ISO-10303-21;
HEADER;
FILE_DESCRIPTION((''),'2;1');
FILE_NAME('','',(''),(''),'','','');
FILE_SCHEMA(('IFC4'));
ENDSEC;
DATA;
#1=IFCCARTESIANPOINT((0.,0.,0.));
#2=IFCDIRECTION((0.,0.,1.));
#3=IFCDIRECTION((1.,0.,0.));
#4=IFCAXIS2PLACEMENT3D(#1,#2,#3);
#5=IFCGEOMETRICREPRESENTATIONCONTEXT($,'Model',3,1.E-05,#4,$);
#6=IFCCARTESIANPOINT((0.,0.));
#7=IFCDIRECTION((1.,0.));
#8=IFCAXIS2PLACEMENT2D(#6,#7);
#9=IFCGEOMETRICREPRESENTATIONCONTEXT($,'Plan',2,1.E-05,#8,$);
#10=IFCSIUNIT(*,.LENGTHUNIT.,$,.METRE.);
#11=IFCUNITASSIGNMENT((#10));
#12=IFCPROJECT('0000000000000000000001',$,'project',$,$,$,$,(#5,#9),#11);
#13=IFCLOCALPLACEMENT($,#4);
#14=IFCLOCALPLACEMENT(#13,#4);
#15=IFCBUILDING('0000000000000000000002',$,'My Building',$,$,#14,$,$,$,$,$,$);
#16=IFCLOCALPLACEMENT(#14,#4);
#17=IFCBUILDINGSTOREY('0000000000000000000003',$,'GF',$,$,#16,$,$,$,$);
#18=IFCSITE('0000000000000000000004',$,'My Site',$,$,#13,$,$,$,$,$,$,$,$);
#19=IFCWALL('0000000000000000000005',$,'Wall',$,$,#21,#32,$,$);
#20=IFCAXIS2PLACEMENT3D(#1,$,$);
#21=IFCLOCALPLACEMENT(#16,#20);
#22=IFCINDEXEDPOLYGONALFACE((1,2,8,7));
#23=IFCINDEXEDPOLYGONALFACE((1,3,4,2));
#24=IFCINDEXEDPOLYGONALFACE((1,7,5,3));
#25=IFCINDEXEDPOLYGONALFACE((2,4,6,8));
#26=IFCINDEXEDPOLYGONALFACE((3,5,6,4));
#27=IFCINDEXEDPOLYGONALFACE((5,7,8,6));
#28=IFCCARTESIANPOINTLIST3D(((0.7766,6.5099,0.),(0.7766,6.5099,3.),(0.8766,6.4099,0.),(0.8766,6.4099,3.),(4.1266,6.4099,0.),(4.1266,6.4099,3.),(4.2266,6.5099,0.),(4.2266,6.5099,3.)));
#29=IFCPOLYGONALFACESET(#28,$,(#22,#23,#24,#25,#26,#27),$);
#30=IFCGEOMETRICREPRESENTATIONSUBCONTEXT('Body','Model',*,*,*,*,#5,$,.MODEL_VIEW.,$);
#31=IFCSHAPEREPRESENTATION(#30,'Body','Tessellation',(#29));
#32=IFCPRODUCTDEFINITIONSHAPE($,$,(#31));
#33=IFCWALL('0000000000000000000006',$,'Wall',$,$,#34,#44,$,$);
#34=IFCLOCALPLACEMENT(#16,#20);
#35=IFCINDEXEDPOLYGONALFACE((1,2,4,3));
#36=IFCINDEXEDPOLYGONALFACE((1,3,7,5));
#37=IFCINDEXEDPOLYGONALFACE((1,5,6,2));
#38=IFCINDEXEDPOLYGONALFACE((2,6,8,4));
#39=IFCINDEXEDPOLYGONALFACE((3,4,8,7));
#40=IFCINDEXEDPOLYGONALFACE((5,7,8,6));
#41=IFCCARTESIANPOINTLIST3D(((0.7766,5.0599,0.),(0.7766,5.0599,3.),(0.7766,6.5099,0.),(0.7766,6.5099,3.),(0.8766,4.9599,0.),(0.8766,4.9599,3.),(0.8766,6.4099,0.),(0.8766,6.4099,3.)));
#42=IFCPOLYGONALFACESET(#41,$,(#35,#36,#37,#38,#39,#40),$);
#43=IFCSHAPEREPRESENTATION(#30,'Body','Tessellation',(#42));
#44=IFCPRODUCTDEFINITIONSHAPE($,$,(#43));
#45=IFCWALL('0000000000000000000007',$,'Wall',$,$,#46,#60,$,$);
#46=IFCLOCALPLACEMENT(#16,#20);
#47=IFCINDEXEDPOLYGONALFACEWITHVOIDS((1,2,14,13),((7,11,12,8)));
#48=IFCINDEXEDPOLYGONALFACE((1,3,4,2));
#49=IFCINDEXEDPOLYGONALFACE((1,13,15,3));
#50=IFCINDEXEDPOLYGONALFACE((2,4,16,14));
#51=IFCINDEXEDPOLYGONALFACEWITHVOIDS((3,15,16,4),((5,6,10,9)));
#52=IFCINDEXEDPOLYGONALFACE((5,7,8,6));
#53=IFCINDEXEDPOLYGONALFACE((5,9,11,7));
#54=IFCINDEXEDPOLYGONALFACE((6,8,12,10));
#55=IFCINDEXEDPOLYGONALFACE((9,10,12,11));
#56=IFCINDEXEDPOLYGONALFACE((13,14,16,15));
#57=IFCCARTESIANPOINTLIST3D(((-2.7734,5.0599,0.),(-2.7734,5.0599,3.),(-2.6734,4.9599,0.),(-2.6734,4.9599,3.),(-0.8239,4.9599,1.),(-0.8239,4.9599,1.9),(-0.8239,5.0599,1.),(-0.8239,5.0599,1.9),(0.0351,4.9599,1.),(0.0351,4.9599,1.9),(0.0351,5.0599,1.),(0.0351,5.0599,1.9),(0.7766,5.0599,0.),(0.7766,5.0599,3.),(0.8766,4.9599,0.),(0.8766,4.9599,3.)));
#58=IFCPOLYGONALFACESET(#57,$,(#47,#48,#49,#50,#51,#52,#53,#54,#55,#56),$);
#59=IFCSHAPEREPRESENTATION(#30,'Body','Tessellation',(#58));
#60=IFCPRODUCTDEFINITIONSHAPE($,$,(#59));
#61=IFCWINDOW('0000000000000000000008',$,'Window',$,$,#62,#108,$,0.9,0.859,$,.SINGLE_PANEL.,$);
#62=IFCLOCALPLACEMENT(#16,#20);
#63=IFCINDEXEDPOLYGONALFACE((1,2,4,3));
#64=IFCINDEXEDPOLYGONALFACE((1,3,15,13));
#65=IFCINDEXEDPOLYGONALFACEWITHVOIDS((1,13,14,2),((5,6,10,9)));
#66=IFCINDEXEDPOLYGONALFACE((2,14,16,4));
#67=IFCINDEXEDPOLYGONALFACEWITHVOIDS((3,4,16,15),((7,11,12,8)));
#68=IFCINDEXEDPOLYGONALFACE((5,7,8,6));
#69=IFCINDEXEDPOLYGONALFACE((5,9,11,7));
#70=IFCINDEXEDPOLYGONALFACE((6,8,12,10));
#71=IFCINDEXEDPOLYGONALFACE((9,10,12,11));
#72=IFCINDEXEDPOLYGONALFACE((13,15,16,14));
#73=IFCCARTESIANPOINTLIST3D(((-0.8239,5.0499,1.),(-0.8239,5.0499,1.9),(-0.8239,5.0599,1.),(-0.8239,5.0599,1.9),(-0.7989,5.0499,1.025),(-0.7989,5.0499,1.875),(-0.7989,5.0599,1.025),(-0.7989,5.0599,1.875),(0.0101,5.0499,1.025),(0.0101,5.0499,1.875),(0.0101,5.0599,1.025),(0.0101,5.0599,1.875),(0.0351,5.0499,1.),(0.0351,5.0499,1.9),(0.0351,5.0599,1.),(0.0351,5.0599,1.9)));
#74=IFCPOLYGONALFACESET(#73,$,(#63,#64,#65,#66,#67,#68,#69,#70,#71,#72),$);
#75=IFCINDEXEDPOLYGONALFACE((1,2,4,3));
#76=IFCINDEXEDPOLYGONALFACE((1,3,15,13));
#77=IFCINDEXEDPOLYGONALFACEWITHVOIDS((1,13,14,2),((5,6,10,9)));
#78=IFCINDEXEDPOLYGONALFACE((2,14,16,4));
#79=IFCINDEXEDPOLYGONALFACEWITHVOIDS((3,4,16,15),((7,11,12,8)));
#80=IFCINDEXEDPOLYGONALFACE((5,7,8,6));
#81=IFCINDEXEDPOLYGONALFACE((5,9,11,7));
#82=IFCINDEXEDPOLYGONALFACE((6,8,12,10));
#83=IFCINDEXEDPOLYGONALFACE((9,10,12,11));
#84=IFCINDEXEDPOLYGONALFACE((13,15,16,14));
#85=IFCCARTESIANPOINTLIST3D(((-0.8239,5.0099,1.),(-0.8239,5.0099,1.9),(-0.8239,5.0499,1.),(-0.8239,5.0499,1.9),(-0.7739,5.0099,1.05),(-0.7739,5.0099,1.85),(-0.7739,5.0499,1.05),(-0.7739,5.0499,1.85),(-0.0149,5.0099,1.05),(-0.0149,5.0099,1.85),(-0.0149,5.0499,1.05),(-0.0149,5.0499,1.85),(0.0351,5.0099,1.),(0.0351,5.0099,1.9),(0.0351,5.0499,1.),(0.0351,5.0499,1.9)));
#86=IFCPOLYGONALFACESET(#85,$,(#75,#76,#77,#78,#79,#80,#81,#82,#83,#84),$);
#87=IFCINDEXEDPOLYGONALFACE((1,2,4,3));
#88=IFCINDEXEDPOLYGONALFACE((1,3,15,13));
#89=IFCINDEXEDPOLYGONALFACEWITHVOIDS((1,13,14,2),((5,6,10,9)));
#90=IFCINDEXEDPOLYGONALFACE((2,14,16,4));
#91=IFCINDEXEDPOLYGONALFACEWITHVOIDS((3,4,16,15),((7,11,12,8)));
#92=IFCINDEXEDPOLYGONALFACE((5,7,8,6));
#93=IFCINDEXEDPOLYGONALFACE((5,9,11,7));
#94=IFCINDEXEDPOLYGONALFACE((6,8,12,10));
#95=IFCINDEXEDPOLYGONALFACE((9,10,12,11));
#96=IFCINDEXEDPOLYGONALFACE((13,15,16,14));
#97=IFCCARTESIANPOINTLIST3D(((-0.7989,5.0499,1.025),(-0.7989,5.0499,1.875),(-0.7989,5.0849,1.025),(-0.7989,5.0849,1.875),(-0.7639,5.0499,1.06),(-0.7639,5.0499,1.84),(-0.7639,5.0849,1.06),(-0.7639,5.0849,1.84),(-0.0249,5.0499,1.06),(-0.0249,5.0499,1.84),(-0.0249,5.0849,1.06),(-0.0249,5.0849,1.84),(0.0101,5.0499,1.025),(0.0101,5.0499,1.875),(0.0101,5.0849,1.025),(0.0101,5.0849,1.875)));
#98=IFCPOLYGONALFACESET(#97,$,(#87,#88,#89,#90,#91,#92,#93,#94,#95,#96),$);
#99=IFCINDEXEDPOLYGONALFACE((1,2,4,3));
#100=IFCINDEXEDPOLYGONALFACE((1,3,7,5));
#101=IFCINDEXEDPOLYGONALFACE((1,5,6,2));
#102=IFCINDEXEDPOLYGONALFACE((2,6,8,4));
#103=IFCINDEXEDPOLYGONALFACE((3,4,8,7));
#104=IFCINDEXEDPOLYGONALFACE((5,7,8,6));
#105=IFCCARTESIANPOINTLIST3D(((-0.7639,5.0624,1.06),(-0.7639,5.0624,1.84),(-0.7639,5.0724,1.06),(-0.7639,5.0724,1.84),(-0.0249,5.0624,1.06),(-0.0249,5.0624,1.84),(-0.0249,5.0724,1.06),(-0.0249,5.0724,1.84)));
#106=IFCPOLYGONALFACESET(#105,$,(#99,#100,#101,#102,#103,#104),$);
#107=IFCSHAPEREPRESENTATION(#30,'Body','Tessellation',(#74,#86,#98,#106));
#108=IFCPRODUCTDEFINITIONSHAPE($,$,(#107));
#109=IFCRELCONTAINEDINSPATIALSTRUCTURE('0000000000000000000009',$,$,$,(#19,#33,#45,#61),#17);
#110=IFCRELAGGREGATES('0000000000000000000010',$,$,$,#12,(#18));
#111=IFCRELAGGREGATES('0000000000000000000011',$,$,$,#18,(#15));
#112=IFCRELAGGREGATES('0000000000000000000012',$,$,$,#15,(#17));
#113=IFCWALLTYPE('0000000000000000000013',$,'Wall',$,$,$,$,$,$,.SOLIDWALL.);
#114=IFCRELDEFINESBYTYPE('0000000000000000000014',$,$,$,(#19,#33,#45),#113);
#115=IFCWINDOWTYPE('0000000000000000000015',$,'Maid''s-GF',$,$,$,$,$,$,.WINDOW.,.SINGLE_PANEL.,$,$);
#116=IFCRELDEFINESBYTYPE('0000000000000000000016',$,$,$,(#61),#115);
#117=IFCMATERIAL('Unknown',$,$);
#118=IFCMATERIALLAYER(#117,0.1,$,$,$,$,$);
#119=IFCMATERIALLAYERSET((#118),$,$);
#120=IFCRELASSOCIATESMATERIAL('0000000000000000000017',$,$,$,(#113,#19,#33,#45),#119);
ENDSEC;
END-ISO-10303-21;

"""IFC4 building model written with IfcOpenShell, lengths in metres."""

from ifc_helpers import new_model, entity, si_unit, frame, origin_with_axes, origin_2d_with_axis, place, context, subcontext, project, spatial, line, indexed_curve, outline, extrude, shape, source, transform, mapped, material, layer, layer_set, layer_usage, type_object, type_shapes, element, fill, save


model = new_model("IFC4")

# Units and contexts
model_context = context("Model", 3, precision=1e-05, world=origin_with_axes())
plan_context = context("Plan", 2, precision=1e-05, world=origin_2d_with_axis())
body_context_1 = subcontext(model_context, "Body", "Model", "MODEL_VIEW")
body_context_2 = subcontext(plan_context, "Body", "Plan", "PLAN_VIEW")
ifc_project = project(units=[si_unit("LENGTHUNIT", "METRE")], contexts=[model_context, plan_context])

# Site, building, storey
site_placement = place(None, origin_with_axes())
site = spatial("IfcSite", under=ifc_project, at=site_placement, Name="My Site")
building_placement = place(site_placement, origin_with_axes())
building = spatial("IfcBuilding", under=site, at=building_placement, Name="My Building")
storey_placement = place(building_placement, origin_with_axes())
storey = spatial("IfcBuildingStorey", under=building, at=storey_placement, Name="GF")

# Walls
ifc_material = material(Name="Unknown")
ifc_layer = layer(ifc_material, 0.1)
ifc_layer_set = layer_set([ifc_layer])
ifc_layer_usage_1 = layer_usage(ifc_layer_set, "AXIS2", "POSITIVE", 0.0)
wall_type = type_object("IfcWallType", Name="Wall", PredefinedType="SOLIDWALL", material=ifc_layer_set)
wall_1_placement = place(storey_placement, frame((4.2266, 6.5099, 0.0), z_axis=(0.0, 0.0, 1.0), x_axis=(-1.0, 0.0, 0.0)))
element("IfcWall", 1, at=wall_1_placement, inside=storey, type_object=wall_type, material=ifc_layer_usage_1, Name="Wall", context=body_context_1, shape_type="SweptSolid", body=[
    extrude(outline(indexed_curve([(0.0, 0.0), (0.1, 0.1), (3.35, 0.1), (3.45, 0.0)], segments=[line(1, 2, 3, 4, 1)])), origin_with_axes(), (0.0, 0.0, 1.0), 3.0),
])
ifc_layer_usage_2 = layer_usage(ifc_layer_set, "AXIS2", "POSITIVE", 0.0)
wall_2_placement = place(storey_placement, frame((0.7766, 6.5099, 0.0), z_axis=(0.0, 0.0, 1.0), x_axis=(0.0, -1.0, 0.0)))
element("IfcWall", 2, at=wall_2_placement, inside=storey, type_object=wall_type, material=ifc_layer_usage_2, Name="Wall", context=body_context_1, shape_type="SweptSolid", body=[
    extrude(outline(indexed_curve([(0.0, 0.0), (0.1, 0.1), (1.55, 0.1), (1.45, 0.0)], segments=[line(1, 2, 3, 4, 1)])), origin_with_axes(), (0.0, 0.0, 1.0), 3.0),
])

# Wall, opening, window
ifc_layer_usage_3 = layer_usage(ifc_layer_set, "AXIS2", "POSITIVE", 0.0)
wall_3_placement = place(storey_placement, frame((0.7766, 5.0599, 0.0), z_axis=(0.0, 0.0, 1.0), x_axis=(-1.0, 0.0, 0.0)))
wall_3 = element("IfcWall", 3, at=wall_3_placement, inside=storey, type_object=wall_type, material=ifc_layer_usage_3, Name="Wall", context=body_context_1, shape_type="SweptSolid", body=[
    extrude(outline(indexed_curve([(0.0, 0.0), (-0.1, 0.1), (3.45, 0.1), (3.55, 0.0)], segments=[line(1, 2, 3, 4, 1)])), origin_with_axes(), (0.0, 0.0, 1.0), 3.0),
])
shared_shape_1 = source(origin_with_axes(), body_context_1, "Body", "SweptSolid", [
    extrude(outline(indexed_curve([(0.0, 0.0), (0.859, 0.0), (0.859, 0.9), (0.0, 0.9)], segments=[line(1, 2, 3, 4, 1)])), frame((0.0, -0.6, 0.0), z_axis=(0.0, -1.0, 0.0), x_axis=(1.0, 0.0, 0.0)), (0.0, 0.0, -1.0), 1.2),
])
opening_1_placement = place(wall_3_placement, frame((1.6005, 0.1, 1.0), z_axis=(0.0, 0.0, 1.0), x_axis=(-1.0, 0.000001, 0.0)))
opening_1 = element("IfcOpeningElement", 4, at=opening_1_placement, cuts=wall_3, PredefinedType="OPENING", context=body_context_1, shape_type="MappedRepresentation", body=[
    mapped(shared_shape_1, transform((0.0, 0.0, 0.0), x_axis=(1.0, 0.0, 0.0), y_axis=(0.0, 1.0, 0.0), z_axis=(0.0, 0.0, 1.0), scale=1.0)),
])
window_type_1 = type_object("IfcWindowType", Name="Maid's-GF", PartitioningType="SINGLE_PANEL", PredefinedType="WINDOW")
shared_shape_2 = source(origin_with_axes(), body_context_1, "Body", "SweptSolid", [
    extrude(outline(indexed_curve([(0.0, 0.0), (0.859, 0.0), (0.859, 0.9), (0.0, 0.9)], segments=[line(1, 2, 3, 4, 1)]), holes=[indexed_curve([(0.025, 0.025), (0.834, 0.025), (0.834, 0.875), (0.025, 0.875)], segments=[line(1, 2, 3, 4, 1)])]), frame((0.0, 0.09, 0.0), z_axis=(0.0, -1.0, 0.0), x_axis=(1.0, 0.0, 0.0)), (0.0, 0.0, -1.0), 0.01),
    extrude(outline(indexed_curve([(0.0, 0.0), (0.859, 0.0), (0.859, 0.9), (0.0, 0.9)], segments=[line(1, 2, 3, 4, 1)]), holes=[indexed_curve([(0.05, 0.05), (0.809, 0.05), (0.809, 0.85), (0.05, 0.85)], segments=[line(1, 2, 3, 4, 1)])]), frame((0.0, 0.05, 0.0), z_axis=(0.0, -1.0, 0.0), x_axis=(1.0, 0.0, 0.0)), (0.0, 0.0, -1.0), 0.04),
    extrude(outline(indexed_curve([(0.0, 0.0), (0.809, 0.0), (0.809, 0.85), (0.0, 0.85)], segments=[line(1, 2, 3, 4, 1)]), holes=[indexed_curve([(0.035, 0.035), (0.774, 0.035), (0.774, 0.815), (0.035, 0.815)], segments=[line(1, 2, 3, 4, 1)])]), frame((0.025, 0.09, 0.025), z_axis=(0.0, -1.0, 0.0), x_axis=(1.0, 0.0, 0.0)), (0.0, 0.0, -1.0), 0.035),
    extrude(outline(indexed_curve([(0.035, 0.035), (0.774, 0.035), (0.774, 0.815), (0.035, 0.815)], segments=[line(1, 2, 3, 4, 1)])), frame((0.025, 0.1025, 0.025), z_axis=(0.0, -1.0, 0.0), x_axis=(1.0, 0.0, 0.0)), (0.0, 0.0, -1.0), 0.01),
])
shared_shape_3 = source(origin_with_axes(), body_context_2, "Body", "Curve2D", [
    entity("IfcIndexedPolyCurve", entity("IfcCartesianPointList2D", [[0.05, 0.05], [0.809, 0.05]])),
    entity("IfcIndexedPolyCurve", entity("IfcCartesianPointList2D", [[0.0, 0.1], [0.025, 0.1], [0.025, 0.09], [0.05, 0.09], [0.05, 0.05], [0.0, 0.05]]), [entity("IfcLineIndex", [1, 2, 3, 4, 5, 6, 1])]),
    entity("IfcIndexedPolyCurve", entity("IfcCartesianPointList2D", [[0.859, 0.1], [0.834, 0.1], [0.834, 0.09], [0.809, 0.09], [0.809, 0.05], [0.859, 0.05]]), [entity("IfcLineIndex", [1, 2, 3, 4, 5, 6, 1])]),
    entity("IfcIndexedPolyCurve", entity("IfcCartesianPointList2D", [[0.025, 0.09], [0.06, 0.09], [0.06, 0.125], [0.025, 0.125]]), [entity("IfcLineIndex", [1, 2, 3, 4, 1])]),
    entity("IfcIndexedPolyCurve", entity("IfcCartesianPointList2D", [[0.834, 0.09], [0.799, 0.09], [0.799, 0.125], [0.834, 0.125]]), [entity("IfcLineIndex", [1, 2, 3, 4, 1])]),
    entity("IfcIndexedPolyCurve", entity("IfcCartesianPointList2D", [[0.06, 0.09], [0.799, 0.09]])),
    entity("IfcIndexedPolyCurve", entity("IfcCartesianPointList2D", [[0.06, 0.125], [0.799, 0.125]])),
    entity("IfcIndexedPolyCurve", entity("IfcCartesianPointList2D", [[0.06, 0.1075], [0.799, 0.1075]])),
])
type_shapes(window_type_1, [shared_shape_2, shared_shape_3])
window_1_placement = place(opening_1_placement, frame((0.0, 0.0, 0.0), z_axis=(0.0, 0.0, 1.0), x_axis=(1.0, 0.0, 0.0)))
window_1 = element("IfcWindow", 5, at=window_1_placement, inside=storey, type_object=window_type_1, Name="Window", OverallHeight=0.9, OverallWidth=0.859, PartitioningType="SINGLE_PANEL", shapes=[
    shape(body_context_1, "Body", "MappedRepresentation", [mapped(shared_shape_2, transform((0.0, 0.0, 0.0), x_axis=(1.0, 0.0, 0.0), y_axis=(0.0, 1.0, 0.0), z_axis=(0.0, 0.0, 1.0), scale=1.0))]),
    shape(body_context_2, "Body", "MappedRepresentation", [mapped(shared_shape_3, transform((0.0, 0.0, 0.0), x_axis=(1.0, 0.0, 0.0), y_axis=(0.0, 1.0, 0.0), z_axis=(0.0, 0.0, 1.0), scale=1.0))]),
])
fill(opening_1, window_1)

save(model, "model.ifc")
